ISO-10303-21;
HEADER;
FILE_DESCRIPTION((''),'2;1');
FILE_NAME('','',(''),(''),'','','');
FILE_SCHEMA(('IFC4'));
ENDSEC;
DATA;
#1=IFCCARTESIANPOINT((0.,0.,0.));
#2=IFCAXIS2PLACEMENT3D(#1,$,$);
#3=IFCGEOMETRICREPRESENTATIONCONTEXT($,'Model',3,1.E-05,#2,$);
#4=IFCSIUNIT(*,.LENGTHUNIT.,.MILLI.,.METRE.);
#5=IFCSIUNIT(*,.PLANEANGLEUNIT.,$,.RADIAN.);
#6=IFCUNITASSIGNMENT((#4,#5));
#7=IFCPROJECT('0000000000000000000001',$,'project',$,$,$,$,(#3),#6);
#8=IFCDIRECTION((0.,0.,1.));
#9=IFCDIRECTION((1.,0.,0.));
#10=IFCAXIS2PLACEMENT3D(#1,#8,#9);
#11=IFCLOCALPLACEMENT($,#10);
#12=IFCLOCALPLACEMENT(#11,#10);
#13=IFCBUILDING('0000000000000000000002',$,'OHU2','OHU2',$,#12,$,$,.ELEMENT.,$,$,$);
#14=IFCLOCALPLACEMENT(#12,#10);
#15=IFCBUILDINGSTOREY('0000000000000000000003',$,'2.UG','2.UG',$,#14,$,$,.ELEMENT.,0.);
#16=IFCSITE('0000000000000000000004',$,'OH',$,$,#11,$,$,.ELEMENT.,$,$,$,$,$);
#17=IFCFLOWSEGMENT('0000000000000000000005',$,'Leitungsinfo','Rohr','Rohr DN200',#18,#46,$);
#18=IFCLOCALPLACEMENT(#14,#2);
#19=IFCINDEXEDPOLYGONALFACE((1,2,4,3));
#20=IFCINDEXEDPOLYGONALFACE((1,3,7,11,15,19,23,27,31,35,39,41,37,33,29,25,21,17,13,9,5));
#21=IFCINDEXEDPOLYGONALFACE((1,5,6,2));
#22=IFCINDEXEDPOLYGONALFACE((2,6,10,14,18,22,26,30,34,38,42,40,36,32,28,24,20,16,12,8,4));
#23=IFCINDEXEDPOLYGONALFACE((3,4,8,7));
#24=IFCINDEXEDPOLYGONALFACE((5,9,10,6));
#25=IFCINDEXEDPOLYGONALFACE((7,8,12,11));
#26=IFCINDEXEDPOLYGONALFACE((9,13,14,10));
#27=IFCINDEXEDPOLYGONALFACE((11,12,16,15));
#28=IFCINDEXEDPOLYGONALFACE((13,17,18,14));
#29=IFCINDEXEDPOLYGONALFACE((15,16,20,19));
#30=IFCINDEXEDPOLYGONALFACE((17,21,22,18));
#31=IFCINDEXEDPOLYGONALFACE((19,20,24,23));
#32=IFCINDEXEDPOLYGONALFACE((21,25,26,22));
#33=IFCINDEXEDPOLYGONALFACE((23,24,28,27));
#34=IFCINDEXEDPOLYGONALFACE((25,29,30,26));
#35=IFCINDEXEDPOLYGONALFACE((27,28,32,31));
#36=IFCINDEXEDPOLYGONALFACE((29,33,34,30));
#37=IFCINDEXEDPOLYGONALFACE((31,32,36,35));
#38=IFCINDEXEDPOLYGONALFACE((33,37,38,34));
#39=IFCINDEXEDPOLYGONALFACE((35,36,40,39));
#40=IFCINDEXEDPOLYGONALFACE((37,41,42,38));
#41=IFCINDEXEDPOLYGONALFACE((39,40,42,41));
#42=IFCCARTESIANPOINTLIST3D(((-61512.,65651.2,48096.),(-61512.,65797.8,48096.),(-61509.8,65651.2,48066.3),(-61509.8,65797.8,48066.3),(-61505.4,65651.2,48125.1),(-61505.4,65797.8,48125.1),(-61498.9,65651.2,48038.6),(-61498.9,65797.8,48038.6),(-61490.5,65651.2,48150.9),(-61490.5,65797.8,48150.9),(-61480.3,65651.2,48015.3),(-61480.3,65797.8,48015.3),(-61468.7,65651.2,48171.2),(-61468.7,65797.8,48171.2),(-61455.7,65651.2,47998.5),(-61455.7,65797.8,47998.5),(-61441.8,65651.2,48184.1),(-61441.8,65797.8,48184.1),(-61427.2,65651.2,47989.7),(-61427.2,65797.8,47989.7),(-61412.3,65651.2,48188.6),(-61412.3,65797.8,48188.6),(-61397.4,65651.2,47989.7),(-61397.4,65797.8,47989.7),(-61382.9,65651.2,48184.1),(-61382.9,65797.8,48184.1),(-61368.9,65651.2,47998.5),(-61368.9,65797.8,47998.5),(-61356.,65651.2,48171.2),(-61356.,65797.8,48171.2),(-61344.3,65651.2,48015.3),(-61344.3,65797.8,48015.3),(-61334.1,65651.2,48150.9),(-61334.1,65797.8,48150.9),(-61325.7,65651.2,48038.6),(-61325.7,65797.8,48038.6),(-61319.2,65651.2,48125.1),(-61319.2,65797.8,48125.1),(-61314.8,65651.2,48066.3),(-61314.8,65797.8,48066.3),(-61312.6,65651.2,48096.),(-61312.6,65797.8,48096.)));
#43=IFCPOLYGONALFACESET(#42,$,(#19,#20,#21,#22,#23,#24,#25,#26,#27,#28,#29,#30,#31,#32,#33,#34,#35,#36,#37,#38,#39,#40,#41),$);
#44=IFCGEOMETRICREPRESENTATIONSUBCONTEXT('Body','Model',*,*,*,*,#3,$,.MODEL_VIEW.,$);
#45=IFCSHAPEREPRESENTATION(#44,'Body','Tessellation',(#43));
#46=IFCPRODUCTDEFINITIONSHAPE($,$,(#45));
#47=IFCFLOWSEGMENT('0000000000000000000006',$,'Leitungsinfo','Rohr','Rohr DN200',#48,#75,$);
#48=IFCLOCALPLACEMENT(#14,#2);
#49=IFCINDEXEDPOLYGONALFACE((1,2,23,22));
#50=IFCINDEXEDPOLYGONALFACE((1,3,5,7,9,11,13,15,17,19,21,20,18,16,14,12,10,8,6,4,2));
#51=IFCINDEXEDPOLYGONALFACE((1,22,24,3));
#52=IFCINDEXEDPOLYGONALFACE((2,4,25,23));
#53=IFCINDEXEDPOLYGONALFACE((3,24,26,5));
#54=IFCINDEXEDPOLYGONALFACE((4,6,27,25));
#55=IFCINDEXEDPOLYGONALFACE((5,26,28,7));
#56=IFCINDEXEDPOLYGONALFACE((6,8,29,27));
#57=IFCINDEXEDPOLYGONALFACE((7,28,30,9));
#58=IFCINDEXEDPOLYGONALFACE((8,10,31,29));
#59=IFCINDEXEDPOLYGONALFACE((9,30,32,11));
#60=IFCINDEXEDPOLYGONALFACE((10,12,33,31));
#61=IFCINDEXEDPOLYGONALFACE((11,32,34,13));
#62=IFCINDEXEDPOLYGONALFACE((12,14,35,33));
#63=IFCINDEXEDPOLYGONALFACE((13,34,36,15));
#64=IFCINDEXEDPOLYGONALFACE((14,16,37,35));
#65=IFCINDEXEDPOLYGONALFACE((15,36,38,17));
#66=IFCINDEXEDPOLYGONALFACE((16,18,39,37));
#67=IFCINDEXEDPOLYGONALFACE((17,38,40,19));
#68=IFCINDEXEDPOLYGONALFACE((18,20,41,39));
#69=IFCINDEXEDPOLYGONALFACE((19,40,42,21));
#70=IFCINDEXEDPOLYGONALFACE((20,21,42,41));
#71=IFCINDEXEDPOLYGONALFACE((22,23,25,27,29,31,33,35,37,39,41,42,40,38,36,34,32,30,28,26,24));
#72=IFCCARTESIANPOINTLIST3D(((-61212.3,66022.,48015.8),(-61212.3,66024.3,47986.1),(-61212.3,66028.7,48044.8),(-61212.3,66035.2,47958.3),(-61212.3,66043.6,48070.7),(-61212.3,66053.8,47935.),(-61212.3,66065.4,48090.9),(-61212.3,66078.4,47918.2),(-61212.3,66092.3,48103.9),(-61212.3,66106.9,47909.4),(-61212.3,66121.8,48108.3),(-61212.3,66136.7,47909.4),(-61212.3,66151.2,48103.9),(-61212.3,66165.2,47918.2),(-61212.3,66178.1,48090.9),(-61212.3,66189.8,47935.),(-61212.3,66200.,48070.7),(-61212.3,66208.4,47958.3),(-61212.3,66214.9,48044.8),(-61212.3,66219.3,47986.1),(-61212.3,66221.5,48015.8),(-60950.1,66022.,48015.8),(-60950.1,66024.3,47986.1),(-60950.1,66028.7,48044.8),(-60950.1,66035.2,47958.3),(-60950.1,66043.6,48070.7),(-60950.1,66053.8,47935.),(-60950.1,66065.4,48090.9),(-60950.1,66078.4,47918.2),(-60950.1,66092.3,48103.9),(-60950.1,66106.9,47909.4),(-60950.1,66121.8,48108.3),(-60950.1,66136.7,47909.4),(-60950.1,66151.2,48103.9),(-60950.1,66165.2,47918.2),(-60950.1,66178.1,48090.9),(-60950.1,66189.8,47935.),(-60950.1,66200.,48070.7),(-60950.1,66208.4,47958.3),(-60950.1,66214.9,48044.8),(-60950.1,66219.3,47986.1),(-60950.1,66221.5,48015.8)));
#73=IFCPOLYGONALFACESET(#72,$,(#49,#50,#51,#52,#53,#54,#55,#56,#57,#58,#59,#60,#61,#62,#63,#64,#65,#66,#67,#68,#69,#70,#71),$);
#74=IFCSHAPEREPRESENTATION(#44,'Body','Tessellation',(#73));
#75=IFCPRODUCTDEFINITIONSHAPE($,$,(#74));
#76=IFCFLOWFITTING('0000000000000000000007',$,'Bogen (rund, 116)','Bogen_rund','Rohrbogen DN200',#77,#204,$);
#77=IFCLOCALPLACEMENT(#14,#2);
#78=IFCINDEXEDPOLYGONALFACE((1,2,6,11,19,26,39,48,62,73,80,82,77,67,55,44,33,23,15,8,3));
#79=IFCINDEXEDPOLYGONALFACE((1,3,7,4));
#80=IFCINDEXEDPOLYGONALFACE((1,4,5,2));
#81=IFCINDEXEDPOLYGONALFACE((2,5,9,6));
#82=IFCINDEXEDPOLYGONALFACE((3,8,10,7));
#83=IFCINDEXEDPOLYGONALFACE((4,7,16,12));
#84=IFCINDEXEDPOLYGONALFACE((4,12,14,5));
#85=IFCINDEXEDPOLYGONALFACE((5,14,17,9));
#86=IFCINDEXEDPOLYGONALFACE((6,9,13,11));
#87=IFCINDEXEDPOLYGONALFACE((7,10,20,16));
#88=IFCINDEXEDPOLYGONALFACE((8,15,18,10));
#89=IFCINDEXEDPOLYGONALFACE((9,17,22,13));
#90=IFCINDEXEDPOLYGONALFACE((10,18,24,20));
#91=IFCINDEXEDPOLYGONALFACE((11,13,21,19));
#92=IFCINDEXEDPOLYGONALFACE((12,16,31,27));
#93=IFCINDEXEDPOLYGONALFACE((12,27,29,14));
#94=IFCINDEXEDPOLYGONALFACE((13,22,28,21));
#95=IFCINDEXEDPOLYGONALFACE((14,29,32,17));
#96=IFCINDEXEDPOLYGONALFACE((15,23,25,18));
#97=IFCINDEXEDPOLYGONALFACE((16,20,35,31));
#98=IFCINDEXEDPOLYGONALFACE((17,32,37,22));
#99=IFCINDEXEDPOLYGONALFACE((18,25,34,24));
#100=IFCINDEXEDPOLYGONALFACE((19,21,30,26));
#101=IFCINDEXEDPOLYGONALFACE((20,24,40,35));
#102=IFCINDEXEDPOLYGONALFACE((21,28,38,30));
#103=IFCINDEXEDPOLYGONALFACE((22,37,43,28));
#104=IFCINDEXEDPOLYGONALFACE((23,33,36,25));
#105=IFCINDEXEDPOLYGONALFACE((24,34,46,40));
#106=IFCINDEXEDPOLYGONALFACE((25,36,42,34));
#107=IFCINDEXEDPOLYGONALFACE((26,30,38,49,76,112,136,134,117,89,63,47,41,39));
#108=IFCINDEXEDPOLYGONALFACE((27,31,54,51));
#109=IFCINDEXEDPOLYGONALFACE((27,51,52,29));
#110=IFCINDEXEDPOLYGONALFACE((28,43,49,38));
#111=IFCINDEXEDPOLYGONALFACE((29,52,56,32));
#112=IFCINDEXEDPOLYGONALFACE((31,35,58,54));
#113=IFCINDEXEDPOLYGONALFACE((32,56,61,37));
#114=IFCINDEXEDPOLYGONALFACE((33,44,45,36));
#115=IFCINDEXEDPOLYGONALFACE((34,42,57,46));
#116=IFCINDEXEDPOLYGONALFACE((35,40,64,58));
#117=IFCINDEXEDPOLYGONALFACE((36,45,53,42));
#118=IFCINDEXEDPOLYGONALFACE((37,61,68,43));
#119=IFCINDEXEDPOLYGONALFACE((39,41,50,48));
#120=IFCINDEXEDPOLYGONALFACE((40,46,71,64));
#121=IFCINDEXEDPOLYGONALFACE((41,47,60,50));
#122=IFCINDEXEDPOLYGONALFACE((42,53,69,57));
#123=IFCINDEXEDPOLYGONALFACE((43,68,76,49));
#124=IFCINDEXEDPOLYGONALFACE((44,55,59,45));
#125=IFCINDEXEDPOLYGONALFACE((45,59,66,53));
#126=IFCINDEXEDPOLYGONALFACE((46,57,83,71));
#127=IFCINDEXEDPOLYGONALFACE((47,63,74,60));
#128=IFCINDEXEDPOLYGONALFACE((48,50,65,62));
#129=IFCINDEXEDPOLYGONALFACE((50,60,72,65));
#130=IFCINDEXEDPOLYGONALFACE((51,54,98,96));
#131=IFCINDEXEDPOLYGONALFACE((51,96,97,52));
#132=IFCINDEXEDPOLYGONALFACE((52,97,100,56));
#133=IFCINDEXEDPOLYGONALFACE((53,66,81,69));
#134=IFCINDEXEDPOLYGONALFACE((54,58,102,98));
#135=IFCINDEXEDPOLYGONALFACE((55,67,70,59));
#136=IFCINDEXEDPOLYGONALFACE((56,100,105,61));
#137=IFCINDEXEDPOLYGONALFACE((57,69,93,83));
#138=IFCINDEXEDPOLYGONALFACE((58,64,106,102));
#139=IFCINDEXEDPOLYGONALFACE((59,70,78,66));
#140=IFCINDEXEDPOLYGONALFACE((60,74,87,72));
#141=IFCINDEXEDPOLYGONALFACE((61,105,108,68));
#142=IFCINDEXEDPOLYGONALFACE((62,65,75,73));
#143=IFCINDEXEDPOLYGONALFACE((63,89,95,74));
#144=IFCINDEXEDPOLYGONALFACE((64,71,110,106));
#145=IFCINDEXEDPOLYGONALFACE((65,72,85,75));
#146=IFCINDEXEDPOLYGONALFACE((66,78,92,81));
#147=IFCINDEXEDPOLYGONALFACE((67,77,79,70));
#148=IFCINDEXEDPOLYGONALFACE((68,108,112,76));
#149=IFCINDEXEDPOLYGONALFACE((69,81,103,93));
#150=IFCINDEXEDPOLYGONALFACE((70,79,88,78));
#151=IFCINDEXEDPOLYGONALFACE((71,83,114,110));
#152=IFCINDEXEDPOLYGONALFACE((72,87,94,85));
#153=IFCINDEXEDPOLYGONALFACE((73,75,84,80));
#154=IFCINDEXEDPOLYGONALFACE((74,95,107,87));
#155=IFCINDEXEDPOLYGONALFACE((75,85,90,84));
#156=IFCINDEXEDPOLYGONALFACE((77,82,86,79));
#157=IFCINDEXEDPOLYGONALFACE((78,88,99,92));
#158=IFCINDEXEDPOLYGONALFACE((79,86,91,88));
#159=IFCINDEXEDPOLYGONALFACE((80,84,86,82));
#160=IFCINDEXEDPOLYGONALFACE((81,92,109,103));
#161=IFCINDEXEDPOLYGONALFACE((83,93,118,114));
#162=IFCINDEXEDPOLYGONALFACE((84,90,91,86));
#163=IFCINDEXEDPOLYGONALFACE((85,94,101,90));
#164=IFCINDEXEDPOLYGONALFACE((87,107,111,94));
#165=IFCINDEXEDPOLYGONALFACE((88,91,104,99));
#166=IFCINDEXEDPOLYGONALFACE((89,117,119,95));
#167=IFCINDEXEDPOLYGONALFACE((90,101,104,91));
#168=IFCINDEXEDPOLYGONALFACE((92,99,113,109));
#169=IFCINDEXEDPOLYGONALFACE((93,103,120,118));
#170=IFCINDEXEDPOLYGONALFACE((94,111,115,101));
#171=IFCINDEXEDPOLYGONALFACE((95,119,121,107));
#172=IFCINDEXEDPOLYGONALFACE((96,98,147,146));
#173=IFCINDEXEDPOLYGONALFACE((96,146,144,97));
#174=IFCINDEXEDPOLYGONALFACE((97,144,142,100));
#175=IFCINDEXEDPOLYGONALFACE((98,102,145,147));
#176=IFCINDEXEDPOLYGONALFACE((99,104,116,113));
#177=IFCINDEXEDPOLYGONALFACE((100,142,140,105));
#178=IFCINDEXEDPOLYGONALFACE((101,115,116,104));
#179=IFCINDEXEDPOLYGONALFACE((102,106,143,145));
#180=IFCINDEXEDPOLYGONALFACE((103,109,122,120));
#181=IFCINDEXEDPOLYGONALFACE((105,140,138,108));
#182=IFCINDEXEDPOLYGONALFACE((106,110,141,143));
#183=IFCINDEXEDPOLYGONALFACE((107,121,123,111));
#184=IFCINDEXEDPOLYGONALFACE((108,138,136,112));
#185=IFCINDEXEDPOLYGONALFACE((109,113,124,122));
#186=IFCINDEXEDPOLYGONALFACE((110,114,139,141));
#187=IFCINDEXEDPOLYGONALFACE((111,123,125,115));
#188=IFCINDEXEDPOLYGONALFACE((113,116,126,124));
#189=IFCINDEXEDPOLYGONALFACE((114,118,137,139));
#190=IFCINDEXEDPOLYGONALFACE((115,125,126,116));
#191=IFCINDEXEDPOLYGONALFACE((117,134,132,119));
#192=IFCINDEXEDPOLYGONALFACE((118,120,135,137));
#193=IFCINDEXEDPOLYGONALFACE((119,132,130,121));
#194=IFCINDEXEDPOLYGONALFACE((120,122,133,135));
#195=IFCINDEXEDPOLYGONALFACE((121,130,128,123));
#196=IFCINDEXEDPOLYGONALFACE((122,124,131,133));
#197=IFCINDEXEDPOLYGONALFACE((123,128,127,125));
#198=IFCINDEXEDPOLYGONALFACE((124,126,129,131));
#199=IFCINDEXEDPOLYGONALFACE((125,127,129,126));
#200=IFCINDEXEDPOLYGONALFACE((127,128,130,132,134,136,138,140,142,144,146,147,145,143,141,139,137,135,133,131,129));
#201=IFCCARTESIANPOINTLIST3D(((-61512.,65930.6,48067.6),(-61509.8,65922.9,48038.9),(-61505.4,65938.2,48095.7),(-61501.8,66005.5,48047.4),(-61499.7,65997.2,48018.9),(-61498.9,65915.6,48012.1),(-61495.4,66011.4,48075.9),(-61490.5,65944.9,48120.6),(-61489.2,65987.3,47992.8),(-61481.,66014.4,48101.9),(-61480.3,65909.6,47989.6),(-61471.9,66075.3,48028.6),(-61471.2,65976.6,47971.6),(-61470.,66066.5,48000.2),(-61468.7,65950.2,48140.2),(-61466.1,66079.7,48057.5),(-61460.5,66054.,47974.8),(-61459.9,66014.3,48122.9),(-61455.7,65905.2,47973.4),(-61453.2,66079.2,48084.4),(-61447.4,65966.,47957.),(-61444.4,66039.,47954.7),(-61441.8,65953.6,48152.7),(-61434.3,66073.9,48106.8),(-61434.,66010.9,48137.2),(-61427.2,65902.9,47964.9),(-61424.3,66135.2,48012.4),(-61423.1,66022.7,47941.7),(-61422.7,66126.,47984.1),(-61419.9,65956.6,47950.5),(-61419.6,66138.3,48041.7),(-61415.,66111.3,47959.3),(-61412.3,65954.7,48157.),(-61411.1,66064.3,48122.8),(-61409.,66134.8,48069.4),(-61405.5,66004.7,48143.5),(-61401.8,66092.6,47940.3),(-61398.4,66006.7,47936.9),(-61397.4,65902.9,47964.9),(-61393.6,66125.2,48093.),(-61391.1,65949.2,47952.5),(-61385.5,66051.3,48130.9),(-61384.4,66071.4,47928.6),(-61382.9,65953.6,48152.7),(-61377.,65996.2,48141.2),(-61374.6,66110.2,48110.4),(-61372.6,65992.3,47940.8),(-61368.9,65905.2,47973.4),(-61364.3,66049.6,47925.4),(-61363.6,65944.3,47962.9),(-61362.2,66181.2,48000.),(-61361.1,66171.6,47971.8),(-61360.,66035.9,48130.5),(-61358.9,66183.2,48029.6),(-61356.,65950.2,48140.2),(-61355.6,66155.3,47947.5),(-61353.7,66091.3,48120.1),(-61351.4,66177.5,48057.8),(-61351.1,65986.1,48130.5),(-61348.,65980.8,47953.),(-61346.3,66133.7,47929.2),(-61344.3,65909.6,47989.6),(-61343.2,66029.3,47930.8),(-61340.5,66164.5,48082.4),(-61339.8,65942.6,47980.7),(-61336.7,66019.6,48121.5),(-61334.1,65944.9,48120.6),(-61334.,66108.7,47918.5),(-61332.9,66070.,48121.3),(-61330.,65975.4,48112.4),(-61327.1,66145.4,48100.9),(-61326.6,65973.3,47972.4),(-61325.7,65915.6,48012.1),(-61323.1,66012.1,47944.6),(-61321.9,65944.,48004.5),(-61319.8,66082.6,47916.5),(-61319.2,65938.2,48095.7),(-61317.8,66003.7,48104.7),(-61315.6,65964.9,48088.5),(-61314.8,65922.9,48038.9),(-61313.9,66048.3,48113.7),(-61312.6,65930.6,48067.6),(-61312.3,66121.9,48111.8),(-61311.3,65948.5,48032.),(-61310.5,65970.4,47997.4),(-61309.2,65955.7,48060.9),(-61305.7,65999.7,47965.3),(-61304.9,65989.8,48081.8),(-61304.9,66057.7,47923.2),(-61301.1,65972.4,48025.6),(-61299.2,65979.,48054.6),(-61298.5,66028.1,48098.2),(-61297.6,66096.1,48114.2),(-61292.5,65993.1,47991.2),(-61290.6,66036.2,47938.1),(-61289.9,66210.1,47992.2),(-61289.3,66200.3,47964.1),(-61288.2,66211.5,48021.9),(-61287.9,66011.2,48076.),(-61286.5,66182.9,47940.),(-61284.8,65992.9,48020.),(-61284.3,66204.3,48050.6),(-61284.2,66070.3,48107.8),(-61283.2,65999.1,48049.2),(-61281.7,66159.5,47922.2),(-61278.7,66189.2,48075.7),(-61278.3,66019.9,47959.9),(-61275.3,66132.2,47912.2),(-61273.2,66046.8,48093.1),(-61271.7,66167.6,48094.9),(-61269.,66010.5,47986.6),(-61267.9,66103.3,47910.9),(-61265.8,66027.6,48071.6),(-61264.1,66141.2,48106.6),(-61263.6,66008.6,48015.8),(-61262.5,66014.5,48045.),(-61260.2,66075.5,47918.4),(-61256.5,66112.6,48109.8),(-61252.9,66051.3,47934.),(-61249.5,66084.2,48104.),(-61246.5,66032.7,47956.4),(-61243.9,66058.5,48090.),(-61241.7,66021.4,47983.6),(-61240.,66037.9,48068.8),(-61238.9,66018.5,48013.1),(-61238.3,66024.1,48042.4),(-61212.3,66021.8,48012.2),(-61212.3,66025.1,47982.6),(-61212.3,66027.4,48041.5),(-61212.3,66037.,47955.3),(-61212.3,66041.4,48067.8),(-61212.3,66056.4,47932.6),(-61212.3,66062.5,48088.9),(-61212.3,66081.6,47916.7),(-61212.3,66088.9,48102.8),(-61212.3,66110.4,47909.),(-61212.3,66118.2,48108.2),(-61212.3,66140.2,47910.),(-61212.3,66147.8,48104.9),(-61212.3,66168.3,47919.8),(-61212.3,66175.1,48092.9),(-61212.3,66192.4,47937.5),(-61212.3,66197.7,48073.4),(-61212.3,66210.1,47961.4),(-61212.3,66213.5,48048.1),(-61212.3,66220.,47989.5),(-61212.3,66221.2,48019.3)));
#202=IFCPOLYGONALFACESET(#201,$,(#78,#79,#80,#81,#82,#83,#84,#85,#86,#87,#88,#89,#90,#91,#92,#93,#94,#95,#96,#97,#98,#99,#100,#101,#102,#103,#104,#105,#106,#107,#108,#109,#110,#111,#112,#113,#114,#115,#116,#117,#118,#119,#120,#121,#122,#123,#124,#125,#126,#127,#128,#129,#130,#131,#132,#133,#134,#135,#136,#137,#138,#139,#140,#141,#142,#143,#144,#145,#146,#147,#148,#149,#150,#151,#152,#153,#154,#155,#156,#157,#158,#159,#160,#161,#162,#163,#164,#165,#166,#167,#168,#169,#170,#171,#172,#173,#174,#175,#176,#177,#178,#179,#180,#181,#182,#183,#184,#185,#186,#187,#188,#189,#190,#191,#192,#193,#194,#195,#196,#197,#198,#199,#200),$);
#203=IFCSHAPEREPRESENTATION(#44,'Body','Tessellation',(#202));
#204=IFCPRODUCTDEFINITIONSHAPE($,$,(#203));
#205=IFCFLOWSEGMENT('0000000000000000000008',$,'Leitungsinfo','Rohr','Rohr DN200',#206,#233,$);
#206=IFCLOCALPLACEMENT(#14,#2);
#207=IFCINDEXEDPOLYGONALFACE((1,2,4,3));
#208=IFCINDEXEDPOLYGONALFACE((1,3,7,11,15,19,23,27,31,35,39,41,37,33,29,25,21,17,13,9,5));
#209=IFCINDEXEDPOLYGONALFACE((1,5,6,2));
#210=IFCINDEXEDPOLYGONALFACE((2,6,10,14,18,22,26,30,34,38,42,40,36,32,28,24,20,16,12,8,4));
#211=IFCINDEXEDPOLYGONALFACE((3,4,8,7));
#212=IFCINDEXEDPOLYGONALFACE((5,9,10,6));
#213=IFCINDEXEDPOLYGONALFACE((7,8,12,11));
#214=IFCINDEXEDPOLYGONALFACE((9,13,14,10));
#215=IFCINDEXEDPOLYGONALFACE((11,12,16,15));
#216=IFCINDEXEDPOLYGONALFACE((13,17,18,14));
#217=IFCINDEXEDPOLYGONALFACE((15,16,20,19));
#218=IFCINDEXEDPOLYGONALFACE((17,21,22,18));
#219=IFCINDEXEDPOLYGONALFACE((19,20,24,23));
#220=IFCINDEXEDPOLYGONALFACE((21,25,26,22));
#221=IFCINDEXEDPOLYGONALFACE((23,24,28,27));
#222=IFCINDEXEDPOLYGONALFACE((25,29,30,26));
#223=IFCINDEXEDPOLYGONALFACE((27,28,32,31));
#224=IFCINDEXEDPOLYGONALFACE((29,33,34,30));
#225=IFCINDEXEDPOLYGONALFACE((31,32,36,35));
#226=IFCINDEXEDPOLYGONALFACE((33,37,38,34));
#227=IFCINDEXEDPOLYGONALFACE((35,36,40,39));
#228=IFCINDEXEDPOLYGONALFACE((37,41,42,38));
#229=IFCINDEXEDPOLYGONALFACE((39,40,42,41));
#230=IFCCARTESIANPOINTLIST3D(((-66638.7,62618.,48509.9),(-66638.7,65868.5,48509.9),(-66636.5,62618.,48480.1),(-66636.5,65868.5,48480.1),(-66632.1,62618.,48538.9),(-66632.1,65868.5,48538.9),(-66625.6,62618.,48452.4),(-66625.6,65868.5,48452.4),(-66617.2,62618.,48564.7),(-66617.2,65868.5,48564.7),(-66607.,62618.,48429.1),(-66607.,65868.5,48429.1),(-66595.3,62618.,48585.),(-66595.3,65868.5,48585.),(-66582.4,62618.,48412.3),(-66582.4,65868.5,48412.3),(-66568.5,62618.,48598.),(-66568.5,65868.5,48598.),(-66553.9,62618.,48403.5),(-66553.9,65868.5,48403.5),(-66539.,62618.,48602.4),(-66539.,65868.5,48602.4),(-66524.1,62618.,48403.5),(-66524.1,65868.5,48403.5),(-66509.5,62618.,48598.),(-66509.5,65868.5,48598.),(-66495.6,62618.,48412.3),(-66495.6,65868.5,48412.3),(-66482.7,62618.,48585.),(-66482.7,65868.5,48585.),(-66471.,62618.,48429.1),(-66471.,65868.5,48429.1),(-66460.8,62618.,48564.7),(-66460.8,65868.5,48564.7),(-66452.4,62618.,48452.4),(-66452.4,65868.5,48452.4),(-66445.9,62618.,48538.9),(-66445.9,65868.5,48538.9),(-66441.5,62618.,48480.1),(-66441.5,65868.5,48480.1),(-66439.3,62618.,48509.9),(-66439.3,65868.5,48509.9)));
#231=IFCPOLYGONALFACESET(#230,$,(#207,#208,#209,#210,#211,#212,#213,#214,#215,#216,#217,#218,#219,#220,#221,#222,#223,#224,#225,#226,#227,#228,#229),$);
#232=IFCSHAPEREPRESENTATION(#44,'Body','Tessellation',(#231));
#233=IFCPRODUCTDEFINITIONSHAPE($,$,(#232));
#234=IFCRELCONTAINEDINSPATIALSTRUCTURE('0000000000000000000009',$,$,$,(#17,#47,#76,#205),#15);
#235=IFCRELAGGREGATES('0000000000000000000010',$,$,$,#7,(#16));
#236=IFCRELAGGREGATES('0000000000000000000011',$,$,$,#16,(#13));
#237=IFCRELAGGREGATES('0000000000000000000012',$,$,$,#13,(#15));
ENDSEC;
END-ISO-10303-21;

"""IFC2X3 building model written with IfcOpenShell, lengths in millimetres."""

from ifc_helpers import new_model, entity, si_unit, frame, origin, origin_with_axes, origin_2d_with_axis, place, context, subcontext, project, spatial, circle, extrude, element, save


model = new_model("IFC2X3")

# Units and contexts
model_context = context("Model", 3, precision=1e-05, world=origin())
body_context = subcontext(model_context, "Body", "Model", "MODEL_VIEW")
ifc_project = project(units=[si_unit("LENGTHUNIT", "METRE", prefix="MILLI"), si_unit("PLANEANGLEUNIT", "RADIAN")], contexts=[model_context])

# Site, building, storey
site_placement = place(None, origin_with_axes())
site = spatial("IfcSite", under=ifc_project, at=site_placement, Name="OH", CompositionType="ELEMENT")
building_placement = place(site_placement, origin_with_axes())
building = spatial("IfcBuilding", under=site, at=building_placement, Name="OHU2", Description="OHU2", CompositionType="ELEMENT")
storey_placement = place(building_placement, origin_with_axes())
storey = spatial("IfcBuildingStorey", under=building, at=storey_placement, Name="2.UG", Description="2.UG", CompositionType="ELEMENT", Elevation=0.0)

# Flow segments
flow_segment_1_placement = place(storey_placement, frame((-61412.3, 65724.5, 48088.6), z_axis=(0.0, 0.0, 1.0), x_axis=(1.0, 0.0, 0.0)))
element("IfcFlowSegment", 1, at=flow_segment_1_placement, inside=storey, Name="Leitungsinfo", Description="Rohr", ObjectType="Rohr DN200", context=body_context, shape_type="SweptSolid", body=[
    extrude(circle(Radius=100.0, at=origin_2d_with_axis()), frame((0.0, 73.3, 0.0), z_axis=(0.0, -1.0, 0.0), x_axis=(0.0, 0.0, 1.0)), (0.0, 0.0, 1.0), 146.6),
])
flow_segment_2_placement = place(storey_placement, frame((-61081.2, 66121.8, 48008.3), z_axis=(0.0, 0.0, 1.0), x_axis=(1.0, 0.0, 0.0)))
element("IfcFlowSegment", 2, at=flow_segment_2_placement, inside=storey, Name="Leitungsinfo", Description="Rohr", ObjectType="Rohr DN200", context=body_context, shape_type="SweptSolid", body=[
    extrude(circle(Radius=100.0, at=origin_2d_with_axis()), frame((-131.1, 0.0, 0.0), z_axis=(1.0, 0.000002, 0.0), x_axis=(0.0, 0.0, 1.0)), (0.0, 0.0, 1.0), 262.3),
])

# Flow fitting
flow_fitting_1_placement = place(storey_placement, frame((-61377.3, 66088.0, 48017.4), z_axis=(0.0, 0.0, 1.0), x_axis=(1.0, 0.0, 0.0)))
element("IfcFlowFitting", 3, at=flow_fitting_1_placement, inside=storey, Name="Bogen (rund, 116)", Description="Bogen_rund", ObjectType="Rohrbogen DN200", context=body_context, shape_type="SweptSolid", body=[
    entity("IfcRevolvedAreaSolid", entity("IfcCircleProfileDef", "AREA", None, entity("IfcAxis2Placement2D", entity("IfcCartesianPoint", [0.0, 0.0]), entity("IfcDirection", [1.0, 0.0])), 100.0), entity("IfcAxis2Placement3D", entity("IfcCartesianPoint", [-35.0, -159.3, 43.0]), entity("IfcDirection", [0.0, 0.965475, -0.260497]), entity("IfcDirection", [0.0, 0.260497, 0.965475])), entity("IfcAxis1Placement", entity("IfcCartesianPoint", [0.0, 200.0, 0.0]), entity("IfcDirection", [-1.0, 0.0, 0.0])), 1.570796),
])

# Flow segment
flow_segment_3_placement = place(storey_placement, frame((-66538.9, 64243.3, 48502.4), z_axis=(0.0, 0.0, 1.0), x_axis=(1.0, 0.0, 0.0)))
element("IfcFlowSegment", 4, at=flow_segment_3_placement, inside=storey, Name="Leitungsinfo", Description="Rohr", ObjectType="Rohr DN200", context=body_context, shape_type="SweptSolid", body=[
    extrude(circle(Radius=100.0, at=origin_2d_with_axis()), frame((-0.1, 1625.3, 0.0), z_axis=(0.0, -1.0, 0.0), x_axis=(0.0, 0.0, 1.0)), (0.0, 0.0, 1.0), 3250.5),
])

save(model, "model.ifc")
